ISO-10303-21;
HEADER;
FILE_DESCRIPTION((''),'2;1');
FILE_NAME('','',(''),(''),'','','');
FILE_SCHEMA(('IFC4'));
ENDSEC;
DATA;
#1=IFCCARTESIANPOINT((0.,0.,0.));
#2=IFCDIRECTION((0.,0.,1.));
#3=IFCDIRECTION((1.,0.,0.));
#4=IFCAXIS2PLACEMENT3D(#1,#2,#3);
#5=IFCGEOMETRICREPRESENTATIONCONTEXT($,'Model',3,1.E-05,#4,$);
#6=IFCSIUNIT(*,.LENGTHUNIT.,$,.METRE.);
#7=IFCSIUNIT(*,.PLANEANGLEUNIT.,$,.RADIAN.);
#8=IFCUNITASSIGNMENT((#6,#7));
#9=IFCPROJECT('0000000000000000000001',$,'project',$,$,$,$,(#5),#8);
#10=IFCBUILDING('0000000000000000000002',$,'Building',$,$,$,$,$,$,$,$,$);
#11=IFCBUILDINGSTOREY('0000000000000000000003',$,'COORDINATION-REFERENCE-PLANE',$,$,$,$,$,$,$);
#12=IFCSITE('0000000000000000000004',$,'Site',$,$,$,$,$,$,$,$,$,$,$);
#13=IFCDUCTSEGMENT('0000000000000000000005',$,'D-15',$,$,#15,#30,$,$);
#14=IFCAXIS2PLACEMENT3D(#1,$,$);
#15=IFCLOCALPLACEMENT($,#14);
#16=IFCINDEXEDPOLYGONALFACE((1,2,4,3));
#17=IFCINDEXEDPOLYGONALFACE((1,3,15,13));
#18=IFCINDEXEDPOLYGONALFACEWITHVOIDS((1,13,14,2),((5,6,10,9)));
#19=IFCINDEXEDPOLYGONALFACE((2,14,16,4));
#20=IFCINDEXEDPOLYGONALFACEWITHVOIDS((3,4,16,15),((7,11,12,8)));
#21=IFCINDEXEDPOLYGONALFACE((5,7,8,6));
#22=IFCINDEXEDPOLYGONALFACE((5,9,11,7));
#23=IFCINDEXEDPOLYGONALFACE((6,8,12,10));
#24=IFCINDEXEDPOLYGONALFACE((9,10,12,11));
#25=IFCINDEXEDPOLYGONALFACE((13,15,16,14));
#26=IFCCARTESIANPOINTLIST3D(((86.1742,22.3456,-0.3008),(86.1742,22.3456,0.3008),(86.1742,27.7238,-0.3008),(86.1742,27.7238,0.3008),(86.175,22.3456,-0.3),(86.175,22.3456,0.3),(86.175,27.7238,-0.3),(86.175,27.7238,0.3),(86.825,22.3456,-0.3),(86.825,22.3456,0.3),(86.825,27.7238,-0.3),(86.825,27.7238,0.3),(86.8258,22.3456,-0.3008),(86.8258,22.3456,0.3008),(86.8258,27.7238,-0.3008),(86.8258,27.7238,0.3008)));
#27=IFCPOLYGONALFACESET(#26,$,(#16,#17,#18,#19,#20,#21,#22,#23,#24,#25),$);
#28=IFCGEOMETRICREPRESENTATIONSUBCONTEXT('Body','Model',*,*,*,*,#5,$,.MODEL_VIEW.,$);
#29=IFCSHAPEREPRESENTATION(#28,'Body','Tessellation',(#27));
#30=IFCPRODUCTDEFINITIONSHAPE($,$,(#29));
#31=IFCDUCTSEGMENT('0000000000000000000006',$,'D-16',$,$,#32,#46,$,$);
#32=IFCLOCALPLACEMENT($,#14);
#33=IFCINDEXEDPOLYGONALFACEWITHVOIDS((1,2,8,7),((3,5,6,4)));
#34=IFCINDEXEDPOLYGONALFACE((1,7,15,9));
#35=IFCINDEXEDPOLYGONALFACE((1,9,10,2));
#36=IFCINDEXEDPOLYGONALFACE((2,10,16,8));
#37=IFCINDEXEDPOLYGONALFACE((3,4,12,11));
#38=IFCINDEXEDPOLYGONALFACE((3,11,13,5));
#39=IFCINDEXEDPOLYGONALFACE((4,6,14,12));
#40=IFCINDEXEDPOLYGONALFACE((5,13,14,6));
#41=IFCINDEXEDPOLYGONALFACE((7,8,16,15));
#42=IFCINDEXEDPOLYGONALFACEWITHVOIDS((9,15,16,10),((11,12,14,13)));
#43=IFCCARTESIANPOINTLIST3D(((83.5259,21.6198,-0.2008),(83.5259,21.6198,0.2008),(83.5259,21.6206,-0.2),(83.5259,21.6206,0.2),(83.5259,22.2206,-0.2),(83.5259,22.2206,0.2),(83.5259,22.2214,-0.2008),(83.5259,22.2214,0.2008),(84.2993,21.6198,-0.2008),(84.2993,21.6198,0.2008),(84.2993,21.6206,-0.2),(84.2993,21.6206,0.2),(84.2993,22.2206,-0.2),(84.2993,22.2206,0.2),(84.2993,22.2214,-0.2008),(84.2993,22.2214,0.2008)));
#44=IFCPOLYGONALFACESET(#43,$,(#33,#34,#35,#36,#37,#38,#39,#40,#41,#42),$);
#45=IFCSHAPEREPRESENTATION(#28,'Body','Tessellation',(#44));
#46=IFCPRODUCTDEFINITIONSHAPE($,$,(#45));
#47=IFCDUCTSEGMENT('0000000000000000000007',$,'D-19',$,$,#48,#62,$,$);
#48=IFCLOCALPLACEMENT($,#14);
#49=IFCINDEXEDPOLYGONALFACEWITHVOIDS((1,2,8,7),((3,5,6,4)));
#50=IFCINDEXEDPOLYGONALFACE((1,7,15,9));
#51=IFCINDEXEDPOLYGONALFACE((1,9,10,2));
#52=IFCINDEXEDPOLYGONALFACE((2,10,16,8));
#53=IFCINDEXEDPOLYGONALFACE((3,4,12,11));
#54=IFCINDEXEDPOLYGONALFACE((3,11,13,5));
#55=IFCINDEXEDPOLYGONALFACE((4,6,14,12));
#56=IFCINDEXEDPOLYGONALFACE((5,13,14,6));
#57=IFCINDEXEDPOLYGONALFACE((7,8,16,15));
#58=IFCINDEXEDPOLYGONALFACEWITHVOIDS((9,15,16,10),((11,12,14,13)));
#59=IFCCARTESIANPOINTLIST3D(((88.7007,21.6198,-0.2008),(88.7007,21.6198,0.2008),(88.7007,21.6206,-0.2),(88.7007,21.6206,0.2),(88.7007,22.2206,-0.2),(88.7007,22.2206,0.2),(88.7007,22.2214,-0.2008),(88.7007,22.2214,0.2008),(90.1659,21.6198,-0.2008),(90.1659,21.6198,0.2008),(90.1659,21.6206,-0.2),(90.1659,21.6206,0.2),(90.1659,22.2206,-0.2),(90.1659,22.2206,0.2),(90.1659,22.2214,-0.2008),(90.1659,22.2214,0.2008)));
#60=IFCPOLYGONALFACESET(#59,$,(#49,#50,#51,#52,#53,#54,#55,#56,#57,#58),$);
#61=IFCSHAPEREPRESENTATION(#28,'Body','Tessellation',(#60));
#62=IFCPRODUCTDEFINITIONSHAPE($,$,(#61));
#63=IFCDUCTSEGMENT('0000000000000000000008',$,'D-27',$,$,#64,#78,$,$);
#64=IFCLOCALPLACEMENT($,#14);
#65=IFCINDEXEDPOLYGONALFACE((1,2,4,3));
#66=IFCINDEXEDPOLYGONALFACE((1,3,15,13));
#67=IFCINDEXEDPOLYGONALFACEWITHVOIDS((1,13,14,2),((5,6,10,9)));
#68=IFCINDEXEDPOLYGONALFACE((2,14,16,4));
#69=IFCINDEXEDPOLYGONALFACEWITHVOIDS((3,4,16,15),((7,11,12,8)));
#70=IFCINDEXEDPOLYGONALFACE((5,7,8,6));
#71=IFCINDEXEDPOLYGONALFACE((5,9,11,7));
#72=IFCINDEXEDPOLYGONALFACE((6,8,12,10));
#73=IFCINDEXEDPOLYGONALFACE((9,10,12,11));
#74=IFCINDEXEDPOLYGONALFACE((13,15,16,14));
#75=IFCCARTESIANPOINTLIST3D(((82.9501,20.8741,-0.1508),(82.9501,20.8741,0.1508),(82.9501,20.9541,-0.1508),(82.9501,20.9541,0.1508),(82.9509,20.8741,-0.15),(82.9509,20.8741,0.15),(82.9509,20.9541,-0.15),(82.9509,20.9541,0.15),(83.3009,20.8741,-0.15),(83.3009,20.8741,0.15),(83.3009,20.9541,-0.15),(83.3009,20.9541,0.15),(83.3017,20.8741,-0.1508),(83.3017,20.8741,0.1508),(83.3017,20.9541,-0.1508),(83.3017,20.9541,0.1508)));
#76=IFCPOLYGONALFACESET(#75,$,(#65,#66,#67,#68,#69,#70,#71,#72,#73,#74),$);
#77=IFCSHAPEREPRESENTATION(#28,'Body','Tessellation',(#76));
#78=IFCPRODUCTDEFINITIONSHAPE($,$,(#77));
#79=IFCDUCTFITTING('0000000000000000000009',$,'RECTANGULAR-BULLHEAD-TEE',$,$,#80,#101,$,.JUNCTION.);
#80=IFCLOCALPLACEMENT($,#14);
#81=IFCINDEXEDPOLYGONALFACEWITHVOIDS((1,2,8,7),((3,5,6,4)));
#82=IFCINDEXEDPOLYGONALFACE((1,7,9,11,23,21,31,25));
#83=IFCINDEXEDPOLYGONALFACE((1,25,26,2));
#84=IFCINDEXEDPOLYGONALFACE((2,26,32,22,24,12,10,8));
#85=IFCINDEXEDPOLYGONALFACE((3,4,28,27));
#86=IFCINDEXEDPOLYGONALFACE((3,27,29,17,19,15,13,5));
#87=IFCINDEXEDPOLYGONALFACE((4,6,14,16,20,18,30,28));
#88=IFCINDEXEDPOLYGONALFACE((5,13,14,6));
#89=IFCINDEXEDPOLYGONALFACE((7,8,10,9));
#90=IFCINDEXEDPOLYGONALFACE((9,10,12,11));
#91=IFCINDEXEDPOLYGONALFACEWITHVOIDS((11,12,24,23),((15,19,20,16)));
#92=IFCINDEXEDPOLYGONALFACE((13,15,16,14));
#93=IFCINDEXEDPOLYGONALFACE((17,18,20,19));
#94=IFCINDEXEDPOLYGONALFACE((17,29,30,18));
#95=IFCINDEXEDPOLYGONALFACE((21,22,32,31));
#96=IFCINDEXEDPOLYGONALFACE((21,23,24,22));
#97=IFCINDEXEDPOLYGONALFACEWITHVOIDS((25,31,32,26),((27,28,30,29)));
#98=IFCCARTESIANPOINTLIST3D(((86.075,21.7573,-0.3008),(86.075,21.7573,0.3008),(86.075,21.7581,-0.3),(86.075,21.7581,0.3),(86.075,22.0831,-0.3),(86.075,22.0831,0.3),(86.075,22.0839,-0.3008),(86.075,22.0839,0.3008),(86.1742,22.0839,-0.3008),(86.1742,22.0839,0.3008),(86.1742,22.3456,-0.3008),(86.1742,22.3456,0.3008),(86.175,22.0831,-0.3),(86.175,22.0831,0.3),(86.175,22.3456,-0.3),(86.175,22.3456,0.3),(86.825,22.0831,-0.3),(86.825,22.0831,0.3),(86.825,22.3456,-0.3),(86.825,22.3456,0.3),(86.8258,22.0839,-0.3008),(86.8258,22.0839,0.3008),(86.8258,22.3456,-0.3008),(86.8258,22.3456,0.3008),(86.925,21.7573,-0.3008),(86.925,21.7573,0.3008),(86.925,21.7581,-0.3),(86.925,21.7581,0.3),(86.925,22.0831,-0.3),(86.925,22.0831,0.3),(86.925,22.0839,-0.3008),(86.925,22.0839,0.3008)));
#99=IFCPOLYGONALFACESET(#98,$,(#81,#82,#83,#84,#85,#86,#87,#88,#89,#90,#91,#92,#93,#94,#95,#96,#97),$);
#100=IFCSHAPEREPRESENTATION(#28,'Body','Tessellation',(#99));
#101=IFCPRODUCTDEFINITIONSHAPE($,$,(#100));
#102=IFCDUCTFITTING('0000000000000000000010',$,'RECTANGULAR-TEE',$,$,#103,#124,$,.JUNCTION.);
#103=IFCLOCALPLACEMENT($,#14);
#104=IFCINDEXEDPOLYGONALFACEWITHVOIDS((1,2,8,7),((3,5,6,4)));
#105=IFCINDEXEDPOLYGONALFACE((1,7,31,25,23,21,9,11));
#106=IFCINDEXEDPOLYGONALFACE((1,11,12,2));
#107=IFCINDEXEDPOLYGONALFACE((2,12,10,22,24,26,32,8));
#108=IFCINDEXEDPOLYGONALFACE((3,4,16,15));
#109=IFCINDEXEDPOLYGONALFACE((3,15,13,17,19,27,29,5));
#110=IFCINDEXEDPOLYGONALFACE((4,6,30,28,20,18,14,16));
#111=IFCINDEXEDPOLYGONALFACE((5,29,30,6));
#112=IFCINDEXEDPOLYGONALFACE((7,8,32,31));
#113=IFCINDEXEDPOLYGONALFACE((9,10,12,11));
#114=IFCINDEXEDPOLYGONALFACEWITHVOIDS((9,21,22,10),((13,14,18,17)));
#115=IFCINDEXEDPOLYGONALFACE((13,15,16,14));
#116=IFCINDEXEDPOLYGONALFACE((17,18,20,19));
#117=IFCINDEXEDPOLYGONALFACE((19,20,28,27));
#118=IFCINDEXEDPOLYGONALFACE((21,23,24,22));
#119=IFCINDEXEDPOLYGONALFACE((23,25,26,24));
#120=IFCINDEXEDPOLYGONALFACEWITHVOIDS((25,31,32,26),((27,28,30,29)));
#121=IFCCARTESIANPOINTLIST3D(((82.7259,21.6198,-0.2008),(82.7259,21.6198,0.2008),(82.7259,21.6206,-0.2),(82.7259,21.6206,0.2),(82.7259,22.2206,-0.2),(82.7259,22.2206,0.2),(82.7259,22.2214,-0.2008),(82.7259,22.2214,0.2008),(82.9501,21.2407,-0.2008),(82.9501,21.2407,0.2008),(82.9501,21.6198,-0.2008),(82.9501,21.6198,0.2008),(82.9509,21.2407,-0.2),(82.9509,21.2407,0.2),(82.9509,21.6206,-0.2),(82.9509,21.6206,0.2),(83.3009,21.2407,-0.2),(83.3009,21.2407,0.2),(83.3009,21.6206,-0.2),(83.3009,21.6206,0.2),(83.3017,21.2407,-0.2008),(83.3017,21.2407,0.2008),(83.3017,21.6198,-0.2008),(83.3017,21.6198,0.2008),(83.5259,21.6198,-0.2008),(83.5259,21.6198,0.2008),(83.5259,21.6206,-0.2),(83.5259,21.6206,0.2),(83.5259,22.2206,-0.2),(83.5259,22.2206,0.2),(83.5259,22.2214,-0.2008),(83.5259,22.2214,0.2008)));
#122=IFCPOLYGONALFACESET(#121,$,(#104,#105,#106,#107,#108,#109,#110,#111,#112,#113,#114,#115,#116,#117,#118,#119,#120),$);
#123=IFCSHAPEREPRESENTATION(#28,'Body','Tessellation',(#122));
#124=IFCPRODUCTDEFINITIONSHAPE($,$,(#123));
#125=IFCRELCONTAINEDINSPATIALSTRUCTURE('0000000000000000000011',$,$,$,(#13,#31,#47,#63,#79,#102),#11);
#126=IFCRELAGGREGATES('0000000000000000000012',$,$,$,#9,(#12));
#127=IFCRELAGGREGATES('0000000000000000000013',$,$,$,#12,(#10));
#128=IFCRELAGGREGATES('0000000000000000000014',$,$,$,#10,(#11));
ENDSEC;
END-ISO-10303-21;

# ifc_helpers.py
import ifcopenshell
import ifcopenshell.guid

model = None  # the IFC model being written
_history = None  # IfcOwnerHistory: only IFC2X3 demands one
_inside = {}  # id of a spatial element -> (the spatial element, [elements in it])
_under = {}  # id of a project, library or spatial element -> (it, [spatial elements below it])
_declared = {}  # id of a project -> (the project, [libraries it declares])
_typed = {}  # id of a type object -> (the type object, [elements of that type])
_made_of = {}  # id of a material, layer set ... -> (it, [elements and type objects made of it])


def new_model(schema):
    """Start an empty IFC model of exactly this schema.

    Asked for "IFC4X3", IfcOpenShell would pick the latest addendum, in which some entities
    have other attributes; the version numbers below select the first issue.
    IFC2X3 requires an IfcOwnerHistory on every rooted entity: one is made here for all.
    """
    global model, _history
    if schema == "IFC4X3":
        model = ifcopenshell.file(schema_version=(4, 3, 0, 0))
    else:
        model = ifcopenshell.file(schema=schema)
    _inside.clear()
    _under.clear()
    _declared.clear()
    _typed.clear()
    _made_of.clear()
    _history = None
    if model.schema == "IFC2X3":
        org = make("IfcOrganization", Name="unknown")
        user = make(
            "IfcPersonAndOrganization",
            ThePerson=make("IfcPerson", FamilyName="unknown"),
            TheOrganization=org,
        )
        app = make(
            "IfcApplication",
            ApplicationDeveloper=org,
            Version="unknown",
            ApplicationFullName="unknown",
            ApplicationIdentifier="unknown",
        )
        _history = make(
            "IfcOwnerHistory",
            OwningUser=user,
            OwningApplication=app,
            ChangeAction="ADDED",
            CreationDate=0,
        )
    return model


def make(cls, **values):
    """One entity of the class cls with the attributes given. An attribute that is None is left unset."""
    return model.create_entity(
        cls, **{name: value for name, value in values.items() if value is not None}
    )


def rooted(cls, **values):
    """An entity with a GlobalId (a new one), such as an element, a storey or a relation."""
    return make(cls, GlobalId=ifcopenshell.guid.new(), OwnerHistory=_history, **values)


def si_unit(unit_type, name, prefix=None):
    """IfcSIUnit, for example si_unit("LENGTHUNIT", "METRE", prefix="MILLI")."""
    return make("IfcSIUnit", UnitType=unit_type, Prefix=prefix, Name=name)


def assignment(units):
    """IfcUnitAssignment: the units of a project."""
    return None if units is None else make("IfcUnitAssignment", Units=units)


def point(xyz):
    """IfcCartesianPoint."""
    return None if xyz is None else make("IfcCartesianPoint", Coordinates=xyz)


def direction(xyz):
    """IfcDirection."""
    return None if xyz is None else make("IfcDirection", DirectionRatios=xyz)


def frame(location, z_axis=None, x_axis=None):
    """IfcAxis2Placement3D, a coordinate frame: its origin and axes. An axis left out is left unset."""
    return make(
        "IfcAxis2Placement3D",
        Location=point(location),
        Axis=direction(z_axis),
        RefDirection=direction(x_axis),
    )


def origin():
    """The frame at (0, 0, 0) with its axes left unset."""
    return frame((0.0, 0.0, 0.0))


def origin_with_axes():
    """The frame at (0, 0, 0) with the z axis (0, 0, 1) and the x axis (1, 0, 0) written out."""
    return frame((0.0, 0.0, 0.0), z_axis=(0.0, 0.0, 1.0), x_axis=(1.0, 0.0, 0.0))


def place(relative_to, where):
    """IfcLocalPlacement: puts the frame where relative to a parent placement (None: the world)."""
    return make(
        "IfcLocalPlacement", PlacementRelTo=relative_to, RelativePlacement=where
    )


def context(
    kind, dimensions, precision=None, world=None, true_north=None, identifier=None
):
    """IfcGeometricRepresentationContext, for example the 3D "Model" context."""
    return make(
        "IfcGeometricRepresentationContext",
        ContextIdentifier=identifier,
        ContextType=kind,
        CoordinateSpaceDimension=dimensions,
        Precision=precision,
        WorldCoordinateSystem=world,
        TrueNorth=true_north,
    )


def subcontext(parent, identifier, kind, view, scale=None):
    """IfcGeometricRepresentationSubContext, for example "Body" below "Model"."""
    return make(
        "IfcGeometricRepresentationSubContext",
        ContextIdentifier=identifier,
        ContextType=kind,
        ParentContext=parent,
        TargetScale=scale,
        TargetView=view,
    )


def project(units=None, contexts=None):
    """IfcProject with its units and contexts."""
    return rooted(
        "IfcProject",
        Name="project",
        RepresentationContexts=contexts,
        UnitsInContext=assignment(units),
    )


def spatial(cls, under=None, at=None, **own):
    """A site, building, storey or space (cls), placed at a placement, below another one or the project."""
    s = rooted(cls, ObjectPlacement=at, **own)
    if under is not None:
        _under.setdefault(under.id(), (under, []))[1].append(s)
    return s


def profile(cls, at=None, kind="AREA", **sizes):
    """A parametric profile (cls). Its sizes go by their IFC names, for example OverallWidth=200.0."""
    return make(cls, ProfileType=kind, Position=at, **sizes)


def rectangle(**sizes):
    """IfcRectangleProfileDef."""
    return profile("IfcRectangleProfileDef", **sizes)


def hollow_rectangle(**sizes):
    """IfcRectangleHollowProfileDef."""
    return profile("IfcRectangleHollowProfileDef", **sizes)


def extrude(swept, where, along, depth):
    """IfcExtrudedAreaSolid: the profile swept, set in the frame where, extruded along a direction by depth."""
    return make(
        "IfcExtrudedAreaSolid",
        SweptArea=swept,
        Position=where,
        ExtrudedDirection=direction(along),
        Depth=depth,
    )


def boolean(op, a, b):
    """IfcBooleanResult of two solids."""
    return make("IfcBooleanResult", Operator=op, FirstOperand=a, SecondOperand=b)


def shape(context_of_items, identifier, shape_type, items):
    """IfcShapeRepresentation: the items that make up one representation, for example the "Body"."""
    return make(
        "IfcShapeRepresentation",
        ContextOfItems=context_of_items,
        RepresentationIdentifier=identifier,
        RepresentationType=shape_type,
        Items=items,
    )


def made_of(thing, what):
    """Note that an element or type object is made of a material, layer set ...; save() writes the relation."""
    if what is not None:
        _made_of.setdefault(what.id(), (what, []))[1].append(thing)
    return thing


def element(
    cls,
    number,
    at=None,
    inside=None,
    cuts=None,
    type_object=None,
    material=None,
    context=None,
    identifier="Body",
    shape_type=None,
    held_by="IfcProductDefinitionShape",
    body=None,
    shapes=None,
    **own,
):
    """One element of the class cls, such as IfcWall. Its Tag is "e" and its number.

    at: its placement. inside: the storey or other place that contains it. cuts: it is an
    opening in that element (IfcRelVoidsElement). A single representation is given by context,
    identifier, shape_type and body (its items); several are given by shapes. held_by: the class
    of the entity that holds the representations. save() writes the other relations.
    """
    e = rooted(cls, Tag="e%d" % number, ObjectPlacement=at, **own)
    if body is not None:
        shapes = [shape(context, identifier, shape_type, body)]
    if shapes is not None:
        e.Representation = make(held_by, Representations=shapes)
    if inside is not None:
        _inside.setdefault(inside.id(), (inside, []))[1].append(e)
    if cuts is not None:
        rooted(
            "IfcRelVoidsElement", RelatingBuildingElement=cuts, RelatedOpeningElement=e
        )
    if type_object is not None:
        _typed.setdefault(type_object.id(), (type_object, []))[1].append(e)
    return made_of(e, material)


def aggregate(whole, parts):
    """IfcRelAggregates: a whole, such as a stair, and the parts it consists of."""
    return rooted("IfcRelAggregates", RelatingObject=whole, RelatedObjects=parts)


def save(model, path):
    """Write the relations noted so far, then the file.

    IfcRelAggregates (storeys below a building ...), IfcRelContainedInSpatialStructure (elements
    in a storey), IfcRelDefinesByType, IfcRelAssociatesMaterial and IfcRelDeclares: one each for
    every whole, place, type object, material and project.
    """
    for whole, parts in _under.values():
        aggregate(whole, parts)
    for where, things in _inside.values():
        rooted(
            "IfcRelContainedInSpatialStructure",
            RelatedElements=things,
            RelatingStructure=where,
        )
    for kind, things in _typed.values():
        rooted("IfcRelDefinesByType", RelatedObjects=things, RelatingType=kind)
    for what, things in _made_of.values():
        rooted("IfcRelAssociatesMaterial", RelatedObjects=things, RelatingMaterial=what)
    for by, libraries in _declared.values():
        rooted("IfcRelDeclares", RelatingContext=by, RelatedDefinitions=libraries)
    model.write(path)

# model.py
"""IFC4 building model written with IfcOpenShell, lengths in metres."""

from ifc_helpers import new_model, si_unit, frame, origin, origin_with_axes, place, context, subcontext, project, spatial, rectangle, hollow_rectangle, extrude, boolean, element, save


model = new_model("IFC4")

# Units and contexts
model_context = context("Model", 3, precision=1e-05, world=origin_with_axes())
body_context_1 = subcontext(model_context, "Body", "Model", "MODEL_VIEW")
ifc_project = project(units=[si_unit("LENGTHUNIT", "METRE"), si_unit("PLANEANGLEUNIT", "RADIAN")], contexts=[model_context])

# Site, building, storey
site = spatial("IfcSite", under=ifc_project, Name="Site")
building = spatial("IfcBuilding", under=site, Name="Building")
storey = spatial("IfcBuildingStorey", under=building, Name="COORDINATION-REFERENCE-PLANE")

# Duct segments
duct_segment_1_placement = place(None, frame((86.5, 22.3456, 0.0), z_axis=(0.0, 1.0, 0.0), x_axis=(1.0, 0.0, 0.0)))
element("IfcDuctSegment", 1, at=duct_segment_1_placement, inside=storey, Name="D-15", context=body_context_1, shape_type="SweptSolid", body=[
    extrude(hollow_rectangle(XDim=0.6516, YDim=0.6016, WallThickness=0.0008), origin(), (0.0, 0.0, 1.0), 5.3782),
])
duct_segment_2_placement = place(None, frame((83.5259, 21.9206, 0.0), z_axis=(1.0, 0.0, 0.0), x_axis=(0.0, 1.0, 0.0)))
element("IfcDuctSegment", 2, at=duct_segment_2_placement, inside=storey, Name="D-16", context=body_context_1, shape_type="SweptSolid", body=[
    extrude(hollow_rectangle(XDim=0.6016, YDim=0.4016, WallThickness=0.0008), origin(), (0.0, 0.0, 1.0), 0.7733),
])
duct_segment_3_placement = place(None, frame((88.7007, 21.9206, 0.0), z_axis=(1.0, 0.0, 0.0), x_axis=(0.0, 1.0, 0.0)))
element("IfcDuctSegment", 3, at=duct_segment_3_placement, inside=storey, Name="D-19", context=body_context_1, shape_type="SweptSolid", body=[
    extrude(hollow_rectangle(XDim=0.6016, YDim=0.4016, WallThickness=0.0008), origin(), (0.0, 0.0, 1.0), 1.4652),
])
duct_segment_4_placement = place(None, frame((83.1259, 20.8741, 0.0), z_axis=(0.0, 1.0, 0.0), x_axis=(1.0, 0.0, 0.0)))
element("IfcDuctSegment", 4, at=duct_segment_4_placement, inside=storey, Name="D-27", context=body_context_1, shape_type="SweptSolid", body=[
    extrude(hollow_rectangle(XDim=0.3516, YDim=0.3016, WallThickness=0.0008), origin(), (0.0, 0.0, 1.0), 0.08),
])

# Duct fittings
duct_fitting_1_placement = place(None, frame((86.5, 21.9206, 0.0), z_axis=(1.0, 0.0, 0.0), x_axis=(0.0, 1.0, 0.0)))
solid_1 = boolean("UNION", extrude(rectangle(XDim=0.325, YDim=0.6), frame((0.0, 0.0, -0.425), z_axis=(0.0, 0.0, 1.0), x_axis=(1.0, 0.0, 0.0)), (0.0, 0.0, 1.0), 0.85), extrude(rectangle(XDim=0.65, YDim=0.6), frame((0.0, 0.0, 0.0), z_axis=(1.0, 0.0, 0.0), x_axis=(0.0, 0.0, -1.0)), (0.0, 0.0, 1.0), 0.425))
element("IfcDuctFitting", 5, at=duct_fitting_1_placement, inside=storey, Name="RECTANGULAR-BULLHEAD-TEE", PredefinedType="JUNCTION", context=body_context_1, shape_type="CSG", body=[
    boolean("DIFFERENCE", boolean("UNION", extrude(rectangle(XDim=0.3266, YDim=0.6016), frame((0.0, 0.0, -0.425), z_axis=(0.0, 0.0, 1.0), x_axis=(1.0, 0.0, 0.0)), (0.0, 0.0, 1.0), 0.85), extrude(rectangle(XDim=0.6516, YDim=0.6016), frame((0.0, 0.0, 0.0), z_axis=(1.0, 0.0, 0.0), x_axis=(0.0, 0.0, -1.0)), (0.0, 0.0, 1.0), 0.425)), solid_1),
])
duct_fitting_2_placement = place(None, frame((83.1259, 21.9206, 0.0), z_axis=(-1.0, 0.0, 0.0), x_axis=(0.0, -1.0, 0.0)))
solid_2 = boolean("UNION", extrude(rectangle(XDim=0.6, YDim=0.4), frame((0.0, 0.0, -0.4), z_axis=(0.0, 0.0, 1.0), x_axis=(1.0, 0.0, 0.0)), (0.0, 0.0, 1.0), 0.8), extrude(rectangle(XDim=0.35, YDim=0.4), frame((0.0, 0.0, 0.0), z_axis=(1.0, 0.0, 0.0), x_axis=(0.0, 0.0, -1.0)), (0.0, 0.0, 1.0), 0.6799))
element("IfcDuctFitting", 6, at=duct_fitting_2_placement, inside=storey, Name="RECTANGULAR-TEE", PredefinedType="JUNCTION", context=body_context_1, shape_type="CSG", body=[
    boolean("DIFFERENCE", boolean("UNION", extrude(rectangle(XDim=0.6016, YDim=0.4016), frame((0.0, 0.0, -0.4), z_axis=(0.0, 0.0, 1.0), x_axis=(1.0, 0.0, 0.0)), (0.0, 0.0, 1.0), 0.8), extrude(rectangle(XDim=0.3516, YDim=0.4016), frame((0.0, 0.0, 0.0), z_axis=(1.0, 0.0, 0.0), x_axis=(0.0, 0.0, -1.0)), (0.0, 0.0, 1.0), 0.6799)), solid_2),
])

save(model, "model.ifc")
